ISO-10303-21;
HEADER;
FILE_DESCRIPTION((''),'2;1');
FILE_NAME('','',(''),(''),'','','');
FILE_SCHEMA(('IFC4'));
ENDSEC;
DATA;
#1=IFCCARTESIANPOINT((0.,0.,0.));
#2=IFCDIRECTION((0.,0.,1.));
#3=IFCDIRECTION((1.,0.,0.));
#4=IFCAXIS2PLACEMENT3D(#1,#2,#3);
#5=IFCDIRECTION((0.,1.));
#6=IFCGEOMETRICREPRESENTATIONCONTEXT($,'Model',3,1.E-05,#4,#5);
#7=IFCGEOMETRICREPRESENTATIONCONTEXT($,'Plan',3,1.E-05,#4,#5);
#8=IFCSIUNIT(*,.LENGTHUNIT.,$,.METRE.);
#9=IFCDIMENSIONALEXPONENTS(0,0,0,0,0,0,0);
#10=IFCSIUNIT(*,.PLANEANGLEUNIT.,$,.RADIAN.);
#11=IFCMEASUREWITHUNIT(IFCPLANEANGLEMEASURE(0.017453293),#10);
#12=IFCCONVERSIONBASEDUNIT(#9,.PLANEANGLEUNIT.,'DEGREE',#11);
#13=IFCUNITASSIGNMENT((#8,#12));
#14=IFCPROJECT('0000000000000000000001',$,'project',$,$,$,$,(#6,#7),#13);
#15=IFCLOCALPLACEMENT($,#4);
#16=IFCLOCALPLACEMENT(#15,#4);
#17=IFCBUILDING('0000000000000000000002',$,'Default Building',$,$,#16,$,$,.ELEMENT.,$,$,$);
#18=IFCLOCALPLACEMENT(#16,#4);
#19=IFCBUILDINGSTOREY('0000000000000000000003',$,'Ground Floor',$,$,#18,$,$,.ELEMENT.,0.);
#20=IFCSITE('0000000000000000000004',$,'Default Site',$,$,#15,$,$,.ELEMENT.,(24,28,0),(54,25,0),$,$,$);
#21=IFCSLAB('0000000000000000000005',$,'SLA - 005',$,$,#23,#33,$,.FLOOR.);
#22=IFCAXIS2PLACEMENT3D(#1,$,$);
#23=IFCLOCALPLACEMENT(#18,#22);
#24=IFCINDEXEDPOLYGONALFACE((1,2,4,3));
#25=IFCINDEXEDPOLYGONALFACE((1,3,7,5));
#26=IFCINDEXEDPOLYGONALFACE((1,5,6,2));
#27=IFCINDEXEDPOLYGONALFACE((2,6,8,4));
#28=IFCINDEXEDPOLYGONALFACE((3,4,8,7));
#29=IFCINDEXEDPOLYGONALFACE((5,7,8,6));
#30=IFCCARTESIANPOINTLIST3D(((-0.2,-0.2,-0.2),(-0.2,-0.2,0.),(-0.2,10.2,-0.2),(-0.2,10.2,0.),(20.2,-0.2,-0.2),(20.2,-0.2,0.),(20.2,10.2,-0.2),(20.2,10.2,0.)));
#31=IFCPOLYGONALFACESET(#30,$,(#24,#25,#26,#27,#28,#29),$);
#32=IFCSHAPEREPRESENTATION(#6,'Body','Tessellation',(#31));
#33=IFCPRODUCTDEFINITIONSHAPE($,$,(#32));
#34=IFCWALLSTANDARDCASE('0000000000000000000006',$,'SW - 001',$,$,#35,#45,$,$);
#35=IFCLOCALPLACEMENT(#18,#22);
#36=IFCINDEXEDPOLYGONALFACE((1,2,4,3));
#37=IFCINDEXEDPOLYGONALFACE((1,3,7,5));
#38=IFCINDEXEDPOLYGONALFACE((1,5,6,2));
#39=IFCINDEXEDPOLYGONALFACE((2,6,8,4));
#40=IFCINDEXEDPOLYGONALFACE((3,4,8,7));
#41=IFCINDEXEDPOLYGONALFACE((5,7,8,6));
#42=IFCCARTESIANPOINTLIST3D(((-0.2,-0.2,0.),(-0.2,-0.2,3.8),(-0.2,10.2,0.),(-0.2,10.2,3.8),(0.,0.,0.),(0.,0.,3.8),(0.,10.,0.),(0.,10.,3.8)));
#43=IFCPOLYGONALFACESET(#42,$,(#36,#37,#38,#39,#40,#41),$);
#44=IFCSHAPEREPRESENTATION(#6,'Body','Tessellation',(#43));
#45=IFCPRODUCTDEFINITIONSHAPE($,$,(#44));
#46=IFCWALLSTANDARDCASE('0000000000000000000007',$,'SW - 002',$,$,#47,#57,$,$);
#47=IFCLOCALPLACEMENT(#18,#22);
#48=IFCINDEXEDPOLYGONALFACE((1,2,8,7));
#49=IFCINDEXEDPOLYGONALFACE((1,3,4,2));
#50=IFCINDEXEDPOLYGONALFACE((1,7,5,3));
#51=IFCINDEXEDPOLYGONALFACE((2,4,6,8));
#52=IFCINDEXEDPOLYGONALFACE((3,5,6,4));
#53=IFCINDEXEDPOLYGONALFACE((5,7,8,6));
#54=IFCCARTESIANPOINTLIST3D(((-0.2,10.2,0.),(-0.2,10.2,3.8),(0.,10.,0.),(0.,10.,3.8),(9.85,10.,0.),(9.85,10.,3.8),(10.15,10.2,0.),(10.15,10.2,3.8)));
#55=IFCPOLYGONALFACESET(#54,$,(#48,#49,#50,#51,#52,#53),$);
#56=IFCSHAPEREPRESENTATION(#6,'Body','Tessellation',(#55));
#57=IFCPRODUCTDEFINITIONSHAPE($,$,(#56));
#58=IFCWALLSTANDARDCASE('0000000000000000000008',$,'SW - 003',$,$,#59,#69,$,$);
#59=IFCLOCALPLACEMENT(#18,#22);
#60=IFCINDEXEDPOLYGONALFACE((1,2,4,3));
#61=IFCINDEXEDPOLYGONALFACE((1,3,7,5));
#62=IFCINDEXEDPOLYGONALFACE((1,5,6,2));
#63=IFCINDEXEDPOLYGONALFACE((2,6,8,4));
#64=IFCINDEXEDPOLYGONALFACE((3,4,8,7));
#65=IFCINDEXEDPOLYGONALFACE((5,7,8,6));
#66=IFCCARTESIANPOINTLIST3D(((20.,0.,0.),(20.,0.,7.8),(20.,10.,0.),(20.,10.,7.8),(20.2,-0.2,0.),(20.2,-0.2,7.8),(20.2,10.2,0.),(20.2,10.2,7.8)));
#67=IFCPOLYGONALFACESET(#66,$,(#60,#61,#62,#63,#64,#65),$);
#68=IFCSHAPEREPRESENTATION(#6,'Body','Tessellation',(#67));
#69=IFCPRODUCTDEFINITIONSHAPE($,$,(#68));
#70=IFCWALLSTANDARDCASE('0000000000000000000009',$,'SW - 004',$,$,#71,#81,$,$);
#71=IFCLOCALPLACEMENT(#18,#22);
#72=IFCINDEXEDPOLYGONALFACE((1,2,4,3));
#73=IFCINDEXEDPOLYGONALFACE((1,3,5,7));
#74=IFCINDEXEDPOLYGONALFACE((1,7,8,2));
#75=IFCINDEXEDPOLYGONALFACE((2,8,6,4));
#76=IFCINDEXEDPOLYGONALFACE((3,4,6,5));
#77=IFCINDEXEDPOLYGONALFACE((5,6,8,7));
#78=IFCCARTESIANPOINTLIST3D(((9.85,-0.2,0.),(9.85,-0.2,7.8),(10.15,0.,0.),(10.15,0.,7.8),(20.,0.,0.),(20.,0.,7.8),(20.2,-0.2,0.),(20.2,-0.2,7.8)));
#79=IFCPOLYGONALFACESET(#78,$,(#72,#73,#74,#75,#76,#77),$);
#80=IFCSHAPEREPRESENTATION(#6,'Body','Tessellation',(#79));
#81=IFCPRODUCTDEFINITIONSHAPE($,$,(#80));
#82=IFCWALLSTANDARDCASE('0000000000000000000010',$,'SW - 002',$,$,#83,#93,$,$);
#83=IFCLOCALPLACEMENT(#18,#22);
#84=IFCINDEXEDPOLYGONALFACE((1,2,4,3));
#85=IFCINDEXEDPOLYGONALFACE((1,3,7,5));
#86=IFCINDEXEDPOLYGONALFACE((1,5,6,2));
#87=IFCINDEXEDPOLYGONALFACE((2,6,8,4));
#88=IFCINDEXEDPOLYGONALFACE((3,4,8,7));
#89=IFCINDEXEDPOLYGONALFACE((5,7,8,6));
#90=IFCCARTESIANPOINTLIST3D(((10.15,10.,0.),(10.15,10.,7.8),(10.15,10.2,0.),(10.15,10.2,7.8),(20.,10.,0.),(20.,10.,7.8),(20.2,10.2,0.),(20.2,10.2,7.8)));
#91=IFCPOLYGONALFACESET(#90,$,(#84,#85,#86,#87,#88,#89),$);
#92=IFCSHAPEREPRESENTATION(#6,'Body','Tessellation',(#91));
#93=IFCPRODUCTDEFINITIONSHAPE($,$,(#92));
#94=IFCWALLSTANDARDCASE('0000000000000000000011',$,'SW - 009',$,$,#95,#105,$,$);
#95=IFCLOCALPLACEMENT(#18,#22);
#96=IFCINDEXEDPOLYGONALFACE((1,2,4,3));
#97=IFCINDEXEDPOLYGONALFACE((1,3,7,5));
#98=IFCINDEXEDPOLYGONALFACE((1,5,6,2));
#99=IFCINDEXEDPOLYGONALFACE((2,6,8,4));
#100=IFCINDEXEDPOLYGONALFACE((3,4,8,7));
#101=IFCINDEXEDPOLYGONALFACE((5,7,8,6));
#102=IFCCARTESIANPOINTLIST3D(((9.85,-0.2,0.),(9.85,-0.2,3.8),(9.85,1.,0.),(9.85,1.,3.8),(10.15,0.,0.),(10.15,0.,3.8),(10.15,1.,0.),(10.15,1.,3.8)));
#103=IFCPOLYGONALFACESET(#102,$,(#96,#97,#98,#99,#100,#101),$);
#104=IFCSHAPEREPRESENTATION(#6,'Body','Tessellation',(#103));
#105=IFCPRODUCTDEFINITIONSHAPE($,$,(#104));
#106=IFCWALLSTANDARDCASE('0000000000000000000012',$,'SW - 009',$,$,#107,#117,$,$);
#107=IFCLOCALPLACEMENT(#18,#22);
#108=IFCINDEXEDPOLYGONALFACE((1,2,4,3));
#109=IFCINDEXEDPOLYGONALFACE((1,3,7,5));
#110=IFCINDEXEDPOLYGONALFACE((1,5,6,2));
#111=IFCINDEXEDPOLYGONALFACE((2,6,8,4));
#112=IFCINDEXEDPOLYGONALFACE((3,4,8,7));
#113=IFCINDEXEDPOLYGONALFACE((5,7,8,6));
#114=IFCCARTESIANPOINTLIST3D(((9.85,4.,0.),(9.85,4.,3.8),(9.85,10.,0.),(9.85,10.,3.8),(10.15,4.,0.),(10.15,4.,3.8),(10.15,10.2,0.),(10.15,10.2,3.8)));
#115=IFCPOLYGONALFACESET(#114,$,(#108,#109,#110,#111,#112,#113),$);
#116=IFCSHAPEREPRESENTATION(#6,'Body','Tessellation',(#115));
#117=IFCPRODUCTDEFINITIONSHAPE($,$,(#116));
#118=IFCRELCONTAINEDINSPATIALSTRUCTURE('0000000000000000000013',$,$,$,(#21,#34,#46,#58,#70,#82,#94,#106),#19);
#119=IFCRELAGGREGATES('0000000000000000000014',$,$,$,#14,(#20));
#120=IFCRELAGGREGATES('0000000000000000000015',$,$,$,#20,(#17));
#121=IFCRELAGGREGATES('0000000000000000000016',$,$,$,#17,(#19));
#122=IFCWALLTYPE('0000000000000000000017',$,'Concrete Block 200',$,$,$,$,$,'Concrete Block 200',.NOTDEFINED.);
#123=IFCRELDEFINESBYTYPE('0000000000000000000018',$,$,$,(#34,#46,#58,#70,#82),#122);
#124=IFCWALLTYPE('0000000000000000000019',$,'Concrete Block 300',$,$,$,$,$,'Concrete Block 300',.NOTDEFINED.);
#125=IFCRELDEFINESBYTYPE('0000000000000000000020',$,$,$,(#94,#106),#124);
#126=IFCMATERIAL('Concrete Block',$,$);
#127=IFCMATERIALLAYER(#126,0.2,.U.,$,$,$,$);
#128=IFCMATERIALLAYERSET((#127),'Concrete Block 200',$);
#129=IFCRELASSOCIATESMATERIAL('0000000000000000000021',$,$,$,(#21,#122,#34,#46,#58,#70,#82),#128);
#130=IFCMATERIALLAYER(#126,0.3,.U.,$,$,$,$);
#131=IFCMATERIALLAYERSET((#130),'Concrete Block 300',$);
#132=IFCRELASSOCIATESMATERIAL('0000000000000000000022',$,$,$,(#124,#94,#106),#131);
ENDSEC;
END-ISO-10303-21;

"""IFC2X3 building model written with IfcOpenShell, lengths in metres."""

from ifc_helpers import new_model, entity, si_unit, converted_unit, direction, frame, origin_with_axes, place, context, project, spatial, polyline, outline, extrude, material, layer, layer_set, layer_usage, type_object, element, save


model = new_model("IFC2X3")

# Units and contexts
model_context = context("Model", 3, precision=1e-05, world=origin_with_axes(), true_north=direction((0.0, 1.0)))
plan_context = context("Plan", 3, precision=1e-05, world=origin_with_axes(), true_north=direction((0.0, 1.0)))
ifc_project = project(units=[si_unit("LENGTHUNIT", "METRE"), converted_unit("PLANEANGLEUNIT", "DEGREE", entity("IfcPlaneAngleMeasure", 0.017453293), si_unit("PLANEANGLEUNIT", "RADIAN"), dimensions=[0, 0, 0, 0, 0, 0, 0])], contexts=[model_context, plan_context])

# Site, building, storey
site_placement = place(None, origin_with_axes())
site = spatial("IfcSite", under=ifc_project, at=site_placement, Name="Default Site", CompositionType="ELEMENT", RefLatitude=(24, 28, 0), RefLongitude=(54, 25, 0))
building_placement = place(site_placement, origin_with_axes())
building = spatial("IfcBuilding", under=site, at=building_placement, Name="Default Building", CompositionType="ELEMENT")
storey_placement = place(building_placement, origin_with_axes())
storey = spatial("IfcBuildingStorey", under=building, at=storey_placement, Name="Ground Floor", CompositionType="ELEMENT", Elevation=0.0)

# Slab
ifc_material = material(Name="Concrete Block")
ifc_layer_1 = layer(ifc_material, 0.2, ventilated="UNKNOWN")
ifc_layer_set_1 = layer_set([ifc_layer_1], Name="Concrete Block 200")
ifc_layer_usage_1 = layer_usage(ifc_layer_set_1, "AXIS3", "NEGATIVE", 0.2)
slab_placement = place(storey_placement, frame((-0.2, 10.2, -0.2), z_axis=(0.0, 0.0, 1.0), x_axis=(1.0, 0.0, 0.0)))
element("IfcSlab", 1, at=slab_placement, inside=storey, material=ifc_layer_usage_1, Name="SLA - 005", PredefinedType="FLOOR", context=model_context, shape_type="SweptSolid", body=[
    extrude(outline(polyline([(0.0, 0.0), (20.4, 0.0), (20.4, -10.4), (0.0, -10.4), (0.0, 0.0)])), origin_with_axes(), (0.0, 0.0, 1.0), 0.2),
])

# Walls
ifc_layer_usage_2 = layer_usage(ifc_layer_set_1, "AXIS2", "POSITIVE", 0.0)
wall_type_1 = type_object("IfcWallType", Name="Concrete Block 200", ElementType="Concrete Block 200", PredefinedType="NOTDEFINED", material=ifc_layer_set_1)
wall_1_placement = place(storey_placement, frame((0.0, 0.0, 0.0), z_axis=(0.0, 0.0, 1.0), x_axis=(0.0, 1.0, 0.0)))
element("IfcWallStandardCase", 2, at=wall_1_placement, inside=storey, type_object=wall_type_1, material=ifc_layer_usage_2, Name="SW - 001", context=model_context, shape_type="SweptSolid", body=[
    extrude(outline(polyline([(0.0, 0.0), (10.0, 0.0), (10.2, 0.2), (-0.2, 0.2), (0.0, 0.0)])), origin_with_axes(), (0.0, 0.0, 1.0), 3.8),
])
ifc_layer_usage_3 = layer_usage(ifc_layer_set_1, "AXIS2", "POSITIVE", 0.0)
wall_2_placement = place(storey_placement, frame((0.0, 10.0, 0.0), z_axis=(0.0, 0.0, 1.0), x_axis=(1.0, 0.0, 0.0)))
element("IfcWallStandardCase", 3, at=wall_2_placement, inside=storey, type_object=wall_type_1, material=ifc_layer_usage_3, Name="SW - 002", context=model_context, shape_type="SweptSolid", body=[
    extrude(outline(polyline([(0.0, 0.0), (9.85, 0.0), (10.15, 0.2), (-0.2, 0.2), (0.0, 0.0)])), origin_with_axes(), (0.0, 0.0, 1.0), 3.8),
])
ifc_layer_usage_4 = layer_usage(ifc_layer_set_1, "AXIS2", "POSITIVE", 0.0)
wall_3_placement = place(storey_placement, frame((20.0, 10.0, 0.0), z_axis=(0.0, 0.0, 1.0), x_axis=(0.0, -1.0, 0.0)))
element("IfcWallStandardCase", 4, at=wall_3_placement, inside=storey, type_object=wall_type_1, material=ifc_layer_usage_4, Name="SW - 003", context=model_context, shape_type="SweptSolid", body=[
    extrude(outline(polyline([(0.0, 0.0), (10.0, 0.0), (10.2, 0.2), (-0.2, 0.2), (0.0, 0.0)])), origin_with_axes(), (0.0, 0.0, 1.0), 7.8),
])
ifc_layer_usage_5 = layer_usage(ifc_layer_set_1, "AXIS2", "POSITIVE", 0.0)
wall_4_placement = place(storey_placement, frame((20.0, 0.0, 0.0), z_axis=(0.0, 0.0, 1.0), x_axis=(-1.0, 0.0, 0.0)))
element("IfcWallStandardCase", 5, at=wall_4_placement, inside=storey, type_object=wall_type_1, material=ifc_layer_usage_5, Name="SW - 004", context=model_context, shape_type="SweptSolid", body=[
    extrude(outline(polyline([(0.0, 0.0), (9.85, 0.0), (10.15, 0.2), (-0.2, 0.2), (0.0, 0.0)])), origin_with_axes(), (0.0, 0.0, 1.0), 7.8),
])
ifc_layer_usage_6 = layer_usage(ifc_layer_set_1, "AXIS2", "POSITIVE", 0.0)
wall_5_placement = place(storey_placement, frame((10.15, 10.0, 0.0), z_axis=(0.0, 0.0, 1.0), x_axis=(1.0, 0.0, 0.0)))
element("IfcWallStandardCase", 6, at=wall_5_placement, inside=storey, type_object=wall_type_1, material=ifc_layer_usage_6, Name="SW - 002", context=model_context, shape_type="SweptSolid", body=[
    extrude(outline(polyline([(0.0, 0.0), (9.85, 0.0), (10.05, 0.2), (0.0, 0.2), (0.0, 0.0)])), origin_with_axes(), (0.0, 0.0, 1.0), 7.8),
])
ifc_layer_2 = layer(ifc_material, 0.3, ventilated="UNKNOWN")
ifc_layer_set_2 = layer_set([ifc_layer_2], Name="Concrete Block 300")
ifc_layer_usage_7 = layer_usage(ifc_layer_set_2, "AXIS2", "NEGATIVE", 0.0)
wall_type_2 = type_object("IfcWallType", Name="Concrete Block 300", ElementType="Concrete Block 300", PredefinedType="NOTDEFINED", material=ifc_layer_set_2)
wall_6_placement = place(storey_placement, frame((10.15, 1.0, 0.0), z_axis=(0.0, 0.0, 1.0), x_axis=(0.0, -1.0, 0.0)))
element("IfcWallStandardCase", 7, at=wall_6_placement, inside=storey, type_object=wall_type_2, material=ifc_layer_usage_7, Name="SW - 009", context=model_context, shape_type="SweptSolid", body=[
    extrude(outline(polyline([(0.0, -0.3), (1.2, -0.3), (1.0, 0.0), (0.0, 0.0), (0.0, -0.3)])), origin_with_axes(), (0.0, 0.0, 1.0), 3.8),
])
ifc_layer_usage_8 = layer_usage(ifc_layer_set_2, "AXIS2", "NEGATIVE", 0.0)
wall_7_placement = place(storey_placement, frame((10.15, 10.0, 0.0), z_axis=(0.0, 0.0, 1.0), x_axis=(0.0, -1.0, 0.0)))
element("IfcWallStandardCase", 8, at=wall_7_placement, inside=storey, type_object=wall_type_2, material=ifc_layer_usage_8, Name="SW - 009", context=model_context, shape_type="SweptSolid", body=[
    extrude(outline(polyline([(0.0, -0.3), (6.0, -0.3), (6.0, 0.0), (-0.2, 0.0), (0.0, -0.3)])), origin_with_axes(), (0.0, 0.0, 1.0), 3.8),
])

save(model, "model.ifc")
